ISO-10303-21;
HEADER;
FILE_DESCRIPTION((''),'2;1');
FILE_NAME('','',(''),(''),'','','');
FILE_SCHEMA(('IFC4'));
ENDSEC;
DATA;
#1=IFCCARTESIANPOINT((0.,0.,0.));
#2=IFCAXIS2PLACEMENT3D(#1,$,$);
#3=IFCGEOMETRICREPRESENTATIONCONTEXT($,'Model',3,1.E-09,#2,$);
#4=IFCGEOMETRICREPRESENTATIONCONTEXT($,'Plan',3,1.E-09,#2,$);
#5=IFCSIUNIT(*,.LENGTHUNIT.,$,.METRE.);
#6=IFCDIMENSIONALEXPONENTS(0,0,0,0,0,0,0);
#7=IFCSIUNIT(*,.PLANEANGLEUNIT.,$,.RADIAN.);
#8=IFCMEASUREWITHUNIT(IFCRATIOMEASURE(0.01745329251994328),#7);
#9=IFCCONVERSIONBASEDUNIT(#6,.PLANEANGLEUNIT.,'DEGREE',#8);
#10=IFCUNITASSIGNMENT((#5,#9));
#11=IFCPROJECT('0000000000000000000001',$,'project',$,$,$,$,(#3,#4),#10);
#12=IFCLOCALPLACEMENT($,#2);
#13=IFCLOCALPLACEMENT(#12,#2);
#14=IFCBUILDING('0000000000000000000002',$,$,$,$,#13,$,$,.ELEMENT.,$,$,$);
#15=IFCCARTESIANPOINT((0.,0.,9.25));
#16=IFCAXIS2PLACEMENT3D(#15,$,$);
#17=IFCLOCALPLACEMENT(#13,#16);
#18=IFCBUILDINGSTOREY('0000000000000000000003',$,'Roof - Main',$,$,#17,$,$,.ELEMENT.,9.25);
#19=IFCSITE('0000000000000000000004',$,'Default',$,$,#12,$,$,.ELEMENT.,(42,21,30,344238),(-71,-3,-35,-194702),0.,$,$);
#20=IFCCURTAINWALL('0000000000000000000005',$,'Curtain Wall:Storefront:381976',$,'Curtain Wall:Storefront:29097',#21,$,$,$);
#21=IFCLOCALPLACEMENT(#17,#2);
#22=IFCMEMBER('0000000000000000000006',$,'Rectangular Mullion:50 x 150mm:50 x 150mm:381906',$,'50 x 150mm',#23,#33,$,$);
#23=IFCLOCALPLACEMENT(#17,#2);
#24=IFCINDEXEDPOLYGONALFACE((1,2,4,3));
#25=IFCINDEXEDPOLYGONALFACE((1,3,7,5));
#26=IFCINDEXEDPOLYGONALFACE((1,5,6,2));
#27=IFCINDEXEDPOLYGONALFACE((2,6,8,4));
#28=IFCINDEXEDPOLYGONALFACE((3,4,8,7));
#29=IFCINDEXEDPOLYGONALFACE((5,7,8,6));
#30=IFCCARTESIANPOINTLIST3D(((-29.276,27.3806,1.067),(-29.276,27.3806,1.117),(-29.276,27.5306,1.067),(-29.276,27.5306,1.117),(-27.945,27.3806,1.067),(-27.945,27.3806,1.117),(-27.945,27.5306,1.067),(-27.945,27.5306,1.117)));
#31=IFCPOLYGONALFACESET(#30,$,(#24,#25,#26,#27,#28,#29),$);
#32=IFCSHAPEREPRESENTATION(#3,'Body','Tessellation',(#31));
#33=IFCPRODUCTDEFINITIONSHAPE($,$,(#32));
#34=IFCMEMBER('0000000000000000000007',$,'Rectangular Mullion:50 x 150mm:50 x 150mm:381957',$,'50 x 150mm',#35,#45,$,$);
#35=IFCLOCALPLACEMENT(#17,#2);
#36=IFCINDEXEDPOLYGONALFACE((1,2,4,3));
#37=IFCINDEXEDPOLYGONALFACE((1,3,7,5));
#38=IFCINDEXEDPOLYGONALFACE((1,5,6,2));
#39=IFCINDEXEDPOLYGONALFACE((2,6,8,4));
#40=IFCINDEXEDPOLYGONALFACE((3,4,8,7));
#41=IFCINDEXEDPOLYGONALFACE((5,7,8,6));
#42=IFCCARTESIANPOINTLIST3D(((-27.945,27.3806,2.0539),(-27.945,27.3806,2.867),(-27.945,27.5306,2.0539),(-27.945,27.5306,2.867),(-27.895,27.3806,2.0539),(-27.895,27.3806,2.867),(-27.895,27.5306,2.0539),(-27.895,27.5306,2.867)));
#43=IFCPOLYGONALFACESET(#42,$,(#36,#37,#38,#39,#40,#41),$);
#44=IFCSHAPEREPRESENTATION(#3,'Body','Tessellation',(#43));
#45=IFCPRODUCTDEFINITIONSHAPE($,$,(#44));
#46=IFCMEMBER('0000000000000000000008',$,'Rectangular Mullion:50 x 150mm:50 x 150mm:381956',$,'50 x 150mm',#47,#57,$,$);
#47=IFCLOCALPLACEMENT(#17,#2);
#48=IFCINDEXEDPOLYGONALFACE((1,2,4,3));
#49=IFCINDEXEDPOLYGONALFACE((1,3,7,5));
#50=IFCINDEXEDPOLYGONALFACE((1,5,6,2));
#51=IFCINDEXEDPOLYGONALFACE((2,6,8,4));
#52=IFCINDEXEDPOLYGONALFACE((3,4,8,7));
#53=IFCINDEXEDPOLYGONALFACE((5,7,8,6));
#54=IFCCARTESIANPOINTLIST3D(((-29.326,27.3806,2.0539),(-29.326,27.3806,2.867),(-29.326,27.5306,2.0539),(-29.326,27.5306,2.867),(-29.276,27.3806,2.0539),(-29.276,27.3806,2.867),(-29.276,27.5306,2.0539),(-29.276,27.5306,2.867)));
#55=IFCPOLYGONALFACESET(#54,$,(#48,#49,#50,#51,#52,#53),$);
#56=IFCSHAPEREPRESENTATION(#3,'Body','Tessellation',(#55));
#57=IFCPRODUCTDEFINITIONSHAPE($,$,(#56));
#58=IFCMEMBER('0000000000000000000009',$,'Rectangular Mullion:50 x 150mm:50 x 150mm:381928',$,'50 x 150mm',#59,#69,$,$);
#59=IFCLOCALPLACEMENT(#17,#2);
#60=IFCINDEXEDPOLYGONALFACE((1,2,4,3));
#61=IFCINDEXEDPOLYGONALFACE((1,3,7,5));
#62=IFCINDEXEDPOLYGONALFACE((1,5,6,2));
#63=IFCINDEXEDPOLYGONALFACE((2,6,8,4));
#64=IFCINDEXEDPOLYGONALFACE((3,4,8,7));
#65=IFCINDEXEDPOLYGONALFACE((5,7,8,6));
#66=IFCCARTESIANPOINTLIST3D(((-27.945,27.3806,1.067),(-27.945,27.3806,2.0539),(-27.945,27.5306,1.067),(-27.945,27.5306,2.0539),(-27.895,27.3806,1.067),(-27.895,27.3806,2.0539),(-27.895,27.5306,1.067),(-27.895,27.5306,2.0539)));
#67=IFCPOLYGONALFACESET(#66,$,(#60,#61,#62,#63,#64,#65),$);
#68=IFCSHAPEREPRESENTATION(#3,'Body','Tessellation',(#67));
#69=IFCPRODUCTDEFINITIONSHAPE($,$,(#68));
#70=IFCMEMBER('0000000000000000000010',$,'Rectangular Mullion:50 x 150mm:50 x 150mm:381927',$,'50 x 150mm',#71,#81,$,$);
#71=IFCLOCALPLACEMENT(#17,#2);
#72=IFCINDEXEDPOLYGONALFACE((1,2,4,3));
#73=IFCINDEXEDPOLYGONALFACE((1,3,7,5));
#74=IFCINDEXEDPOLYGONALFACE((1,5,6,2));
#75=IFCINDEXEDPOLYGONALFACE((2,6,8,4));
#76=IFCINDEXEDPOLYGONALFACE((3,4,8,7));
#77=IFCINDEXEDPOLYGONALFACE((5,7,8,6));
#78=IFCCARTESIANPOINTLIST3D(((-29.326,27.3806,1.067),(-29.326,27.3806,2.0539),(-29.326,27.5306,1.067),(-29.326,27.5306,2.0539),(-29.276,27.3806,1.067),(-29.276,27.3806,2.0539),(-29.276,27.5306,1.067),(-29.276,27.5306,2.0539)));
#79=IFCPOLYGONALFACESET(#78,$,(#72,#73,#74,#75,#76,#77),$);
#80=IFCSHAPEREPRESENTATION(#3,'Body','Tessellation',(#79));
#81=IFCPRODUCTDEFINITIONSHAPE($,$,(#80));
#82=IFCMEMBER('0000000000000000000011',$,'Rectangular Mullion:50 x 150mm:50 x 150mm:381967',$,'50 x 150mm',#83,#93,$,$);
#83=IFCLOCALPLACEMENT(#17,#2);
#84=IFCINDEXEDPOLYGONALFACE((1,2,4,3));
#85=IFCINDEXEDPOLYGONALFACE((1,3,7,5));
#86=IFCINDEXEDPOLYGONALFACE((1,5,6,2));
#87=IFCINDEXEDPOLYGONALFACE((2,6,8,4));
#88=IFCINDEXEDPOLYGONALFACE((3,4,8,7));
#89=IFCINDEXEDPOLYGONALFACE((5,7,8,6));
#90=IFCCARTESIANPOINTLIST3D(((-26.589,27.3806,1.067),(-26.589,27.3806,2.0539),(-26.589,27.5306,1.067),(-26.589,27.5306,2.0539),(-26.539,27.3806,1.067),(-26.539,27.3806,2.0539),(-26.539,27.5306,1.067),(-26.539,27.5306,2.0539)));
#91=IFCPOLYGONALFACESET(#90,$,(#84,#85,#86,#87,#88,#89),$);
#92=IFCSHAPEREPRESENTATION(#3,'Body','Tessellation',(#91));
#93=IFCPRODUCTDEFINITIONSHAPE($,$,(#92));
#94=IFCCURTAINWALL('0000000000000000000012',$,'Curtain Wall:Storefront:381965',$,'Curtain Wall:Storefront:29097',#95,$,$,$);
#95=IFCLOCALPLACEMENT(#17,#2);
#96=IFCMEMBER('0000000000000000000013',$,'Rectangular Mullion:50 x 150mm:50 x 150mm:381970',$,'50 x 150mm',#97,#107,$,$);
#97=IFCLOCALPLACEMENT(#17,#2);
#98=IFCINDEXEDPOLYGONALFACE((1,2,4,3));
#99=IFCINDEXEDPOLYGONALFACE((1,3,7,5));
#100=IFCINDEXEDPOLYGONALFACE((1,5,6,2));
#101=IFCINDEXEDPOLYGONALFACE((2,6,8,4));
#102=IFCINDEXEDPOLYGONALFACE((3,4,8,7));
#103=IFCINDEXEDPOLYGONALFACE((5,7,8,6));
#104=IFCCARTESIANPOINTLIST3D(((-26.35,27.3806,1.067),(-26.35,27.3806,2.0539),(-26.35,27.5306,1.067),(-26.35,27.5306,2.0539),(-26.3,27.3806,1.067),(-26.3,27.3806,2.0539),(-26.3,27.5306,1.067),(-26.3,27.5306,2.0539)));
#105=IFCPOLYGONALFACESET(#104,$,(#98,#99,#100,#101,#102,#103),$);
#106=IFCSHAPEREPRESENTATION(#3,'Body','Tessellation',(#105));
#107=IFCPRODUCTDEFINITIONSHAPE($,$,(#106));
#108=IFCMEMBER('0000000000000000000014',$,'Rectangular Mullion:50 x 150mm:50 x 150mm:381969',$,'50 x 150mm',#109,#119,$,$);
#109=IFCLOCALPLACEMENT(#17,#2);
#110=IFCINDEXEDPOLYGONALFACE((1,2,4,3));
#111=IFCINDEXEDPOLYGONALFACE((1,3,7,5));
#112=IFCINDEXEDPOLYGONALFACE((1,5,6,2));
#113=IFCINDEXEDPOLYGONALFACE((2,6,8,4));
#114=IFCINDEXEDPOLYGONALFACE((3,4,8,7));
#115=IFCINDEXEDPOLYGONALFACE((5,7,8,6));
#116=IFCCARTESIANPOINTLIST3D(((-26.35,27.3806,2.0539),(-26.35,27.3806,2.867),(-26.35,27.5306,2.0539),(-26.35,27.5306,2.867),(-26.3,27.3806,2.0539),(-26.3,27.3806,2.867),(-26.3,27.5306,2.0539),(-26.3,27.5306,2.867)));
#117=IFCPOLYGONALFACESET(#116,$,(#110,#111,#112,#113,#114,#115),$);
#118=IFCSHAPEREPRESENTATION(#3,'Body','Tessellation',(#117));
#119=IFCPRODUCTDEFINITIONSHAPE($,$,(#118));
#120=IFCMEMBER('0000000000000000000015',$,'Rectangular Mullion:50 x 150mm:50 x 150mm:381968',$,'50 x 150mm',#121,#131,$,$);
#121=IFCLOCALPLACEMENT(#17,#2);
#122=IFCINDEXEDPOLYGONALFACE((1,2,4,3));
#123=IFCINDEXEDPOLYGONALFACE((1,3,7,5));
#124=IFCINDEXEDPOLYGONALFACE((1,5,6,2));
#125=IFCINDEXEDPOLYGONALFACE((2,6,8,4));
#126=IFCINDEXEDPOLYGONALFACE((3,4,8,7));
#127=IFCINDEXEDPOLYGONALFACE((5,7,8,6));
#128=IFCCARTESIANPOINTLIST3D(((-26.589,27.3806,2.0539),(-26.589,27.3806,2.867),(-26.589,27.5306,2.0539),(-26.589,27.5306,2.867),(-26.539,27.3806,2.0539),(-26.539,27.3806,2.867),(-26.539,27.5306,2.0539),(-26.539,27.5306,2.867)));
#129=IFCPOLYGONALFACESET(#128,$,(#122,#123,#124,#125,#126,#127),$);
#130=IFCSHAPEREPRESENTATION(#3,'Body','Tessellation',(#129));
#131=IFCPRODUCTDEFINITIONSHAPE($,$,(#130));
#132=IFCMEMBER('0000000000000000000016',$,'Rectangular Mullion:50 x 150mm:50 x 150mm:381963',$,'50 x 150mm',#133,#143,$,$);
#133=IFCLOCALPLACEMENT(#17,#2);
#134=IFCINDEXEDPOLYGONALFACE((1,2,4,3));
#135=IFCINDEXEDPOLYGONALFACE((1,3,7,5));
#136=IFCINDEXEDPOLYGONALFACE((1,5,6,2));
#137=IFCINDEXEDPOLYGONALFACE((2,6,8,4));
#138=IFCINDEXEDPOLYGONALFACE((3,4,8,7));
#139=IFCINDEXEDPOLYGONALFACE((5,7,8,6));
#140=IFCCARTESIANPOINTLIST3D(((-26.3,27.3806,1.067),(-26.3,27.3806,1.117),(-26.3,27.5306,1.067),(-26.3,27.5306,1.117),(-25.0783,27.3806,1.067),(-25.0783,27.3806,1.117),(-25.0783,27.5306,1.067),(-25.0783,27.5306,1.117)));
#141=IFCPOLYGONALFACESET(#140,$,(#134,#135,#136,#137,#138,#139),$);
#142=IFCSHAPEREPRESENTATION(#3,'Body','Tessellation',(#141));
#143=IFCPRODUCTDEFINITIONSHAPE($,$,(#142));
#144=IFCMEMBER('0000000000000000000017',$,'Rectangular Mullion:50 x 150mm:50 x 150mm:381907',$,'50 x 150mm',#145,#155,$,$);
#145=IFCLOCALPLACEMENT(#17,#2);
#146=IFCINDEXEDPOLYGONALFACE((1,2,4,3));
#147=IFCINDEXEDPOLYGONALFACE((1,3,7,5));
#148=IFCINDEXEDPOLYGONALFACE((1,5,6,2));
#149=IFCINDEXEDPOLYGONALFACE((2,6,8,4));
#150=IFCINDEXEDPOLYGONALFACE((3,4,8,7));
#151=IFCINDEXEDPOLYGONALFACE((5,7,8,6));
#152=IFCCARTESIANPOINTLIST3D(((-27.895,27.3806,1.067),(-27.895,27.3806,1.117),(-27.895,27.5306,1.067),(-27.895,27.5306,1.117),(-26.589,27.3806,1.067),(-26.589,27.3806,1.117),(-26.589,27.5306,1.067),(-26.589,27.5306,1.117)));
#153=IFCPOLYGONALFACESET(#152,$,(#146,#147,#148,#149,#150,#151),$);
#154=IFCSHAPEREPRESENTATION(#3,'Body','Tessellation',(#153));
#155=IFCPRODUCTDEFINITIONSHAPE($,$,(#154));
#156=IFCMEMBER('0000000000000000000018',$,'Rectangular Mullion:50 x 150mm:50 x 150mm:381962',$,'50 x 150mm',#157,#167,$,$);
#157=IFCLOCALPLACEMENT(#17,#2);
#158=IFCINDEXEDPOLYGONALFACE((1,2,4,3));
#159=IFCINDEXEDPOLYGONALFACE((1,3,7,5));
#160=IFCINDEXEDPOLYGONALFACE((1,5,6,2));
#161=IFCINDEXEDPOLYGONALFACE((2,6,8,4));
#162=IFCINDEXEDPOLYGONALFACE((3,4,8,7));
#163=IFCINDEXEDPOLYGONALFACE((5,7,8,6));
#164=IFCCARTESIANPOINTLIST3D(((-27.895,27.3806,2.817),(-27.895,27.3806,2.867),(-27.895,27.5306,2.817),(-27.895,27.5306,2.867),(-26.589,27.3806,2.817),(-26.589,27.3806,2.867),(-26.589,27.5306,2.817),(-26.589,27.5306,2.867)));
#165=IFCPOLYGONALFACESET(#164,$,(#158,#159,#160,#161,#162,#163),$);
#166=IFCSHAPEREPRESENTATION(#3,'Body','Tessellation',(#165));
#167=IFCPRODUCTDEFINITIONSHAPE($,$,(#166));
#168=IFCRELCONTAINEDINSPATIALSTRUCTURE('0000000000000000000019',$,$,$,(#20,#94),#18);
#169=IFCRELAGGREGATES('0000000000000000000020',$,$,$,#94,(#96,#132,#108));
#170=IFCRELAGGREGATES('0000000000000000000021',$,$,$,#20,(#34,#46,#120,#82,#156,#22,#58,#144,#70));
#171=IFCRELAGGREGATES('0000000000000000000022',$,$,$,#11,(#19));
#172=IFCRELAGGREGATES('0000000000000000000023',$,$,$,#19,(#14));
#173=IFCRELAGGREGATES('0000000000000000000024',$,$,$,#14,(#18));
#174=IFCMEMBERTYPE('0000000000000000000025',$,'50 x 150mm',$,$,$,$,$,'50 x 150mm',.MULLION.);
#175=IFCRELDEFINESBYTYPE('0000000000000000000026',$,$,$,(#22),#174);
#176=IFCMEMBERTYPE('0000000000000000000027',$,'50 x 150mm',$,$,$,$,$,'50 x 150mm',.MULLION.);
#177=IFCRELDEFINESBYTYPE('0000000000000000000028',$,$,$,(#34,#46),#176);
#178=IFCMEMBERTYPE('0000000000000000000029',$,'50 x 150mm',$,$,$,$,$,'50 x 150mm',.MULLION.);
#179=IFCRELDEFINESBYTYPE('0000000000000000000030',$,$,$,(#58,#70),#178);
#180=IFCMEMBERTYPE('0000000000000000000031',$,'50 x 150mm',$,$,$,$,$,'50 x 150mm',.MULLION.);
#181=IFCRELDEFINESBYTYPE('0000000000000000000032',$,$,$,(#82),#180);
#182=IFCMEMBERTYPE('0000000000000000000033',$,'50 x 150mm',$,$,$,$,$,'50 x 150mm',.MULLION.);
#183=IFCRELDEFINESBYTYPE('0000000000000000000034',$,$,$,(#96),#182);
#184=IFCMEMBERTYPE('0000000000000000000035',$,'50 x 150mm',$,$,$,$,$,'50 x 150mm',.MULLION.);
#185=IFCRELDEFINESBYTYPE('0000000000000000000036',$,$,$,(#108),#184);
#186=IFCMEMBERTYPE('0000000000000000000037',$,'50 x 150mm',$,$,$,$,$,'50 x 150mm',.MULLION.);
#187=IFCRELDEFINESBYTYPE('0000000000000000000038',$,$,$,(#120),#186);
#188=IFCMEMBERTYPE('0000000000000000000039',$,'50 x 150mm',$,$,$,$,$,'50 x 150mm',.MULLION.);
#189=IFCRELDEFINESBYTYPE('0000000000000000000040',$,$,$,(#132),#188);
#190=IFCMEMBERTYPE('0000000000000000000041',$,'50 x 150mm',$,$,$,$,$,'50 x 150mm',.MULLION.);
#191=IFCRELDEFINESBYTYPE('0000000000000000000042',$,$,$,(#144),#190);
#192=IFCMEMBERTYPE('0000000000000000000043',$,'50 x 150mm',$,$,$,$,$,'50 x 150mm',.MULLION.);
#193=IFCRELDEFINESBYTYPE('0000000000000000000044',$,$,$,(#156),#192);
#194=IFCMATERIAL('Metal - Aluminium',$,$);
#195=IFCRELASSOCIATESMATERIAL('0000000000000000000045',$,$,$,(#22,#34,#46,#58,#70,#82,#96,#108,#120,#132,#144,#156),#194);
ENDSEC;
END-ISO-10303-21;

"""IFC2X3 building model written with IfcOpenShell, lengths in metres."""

from ifc_helpers import new_model, entity, si_unit, converted_unit, frame, origin, origin_2d_with_axis, place, context, project, spatial, rectangle, extrude, source, transform, mapped, material, type_object, type_shapes, element, aggregate, save


model = new_model("IFC2X3")

# Units and contexts
model_context = context("Model", 3, precision=1e-09, world=origin())
plan_context = context("Plan", 3, precision=1e-09, world=origin())
ifc_project = project(units=[si_unit("LENGTHUNIT", "METRE"), converted_unit("PLANEANGLEUNIT", "DEGREE", entity("IfcRatioMeasure", 0.01745329251994328), si_unit("PLANEANGLEUNIT", "RADIAN"), dimensions=[0, 0, 0, 0, 0, 0, 0])], contexts=[model_context, plan_context])

# Site, building, storey
site_placement = place(None, origin())
site = spatial("IfcSite", under=ifc_project, at=site_placement, Name="Default", CompositionType="ELEMENT", RefLatitude=(42, 21, 30, 344238), RefLongitude=(-71, -3, -35, -194702), RefElevation=0.0)
building_placement = place(site_placement, origin())
building = spatial("IfcBuilding", under=site, at=building_placement, CompositionType="ELEMENT")
storey_placement = place(building_placement, frame((0.0, 0.0, 9.25)))
storey = spatial("IfcBuildingStorey", under=building, at=storey_placement, Name="Roof - Main", CompositionType="ELEMENT", Elevation=9.25)

# Curtain walls, members
curtain_wall_1_placement = place(storey_placement, origin())
curtain_wall_1 = element("IfcCurtainWall", 1, at=curtain_wall_1_placement, inside=storey, Name="Curtain Wall:Storefront:381976", ObjectType="Curtain Wall:Storefront:29097")
ifc_material_1 = material(Name="Metal - Aluminium")
member_type_1 = type_object("IfcMemberType", Name="50 x 150mm", ElementType="50 x 150mm", PredefinedType="MULLION")
shared_shape_1 = source(origin(), model_context, "Body", "SweptSolid", [
    extrude(rectangle(XDim=0.05, YDim=0.15, at=origin_2d_with_axis()), frame((-0.025, 0.0, -1.331), z_axis=(0.0, 0.0, 1.0), x_axis=(-1.0, 0.0, 0.0)), (0.0, 0.0, 1.0), 1.331),
])
type_shapes(member_type_1, [shared_shape_1])
member_1_placement = place(storey_placement, frame((-29.276, 27.4556, 1.067), z_axis=(-1.0, 0.0, 0.0), x_axis=(0.0, 0.0, -1.0)))
member_1 = element("IfcMember", 2, at=member_1_placement, type_object=member_type_1, material=ifc_material_1, Name="Rectangular Mullion:50 x 150mm:50 x 150mm:381906", ObjectType="50 x 150mm", context=model_context, shape_type="MappedRepresentation", body=[
    mapped(shared_shape_1, transform((0.0, 0.0, 0.0), scale=1.0)),
])
member_type_2 = type_object("IfcMemberType", Name="50 x 150mm", ElementType="50 x 150mm", PredefinedType="MULLION")
shared_shape_2 = source(origin(), model_context, "Body", "SweptSolid", [
    extrude(rectangle(XDim=0.05, YDim=0.15, at=origin_2d_with_axis()), frame((0.0, 0.0, -0.8131), z_axis=(0.0, 0.0, 1.0), x_axis=(-1.0, 0.0, 0.0)), (0.0, 0.0, 1.0), 0.8131),
])
type_shapes(member_type_2, [shared_shape_2])
member_2_placement = place(storey_placement, frame((-27.92, 27.4556, 2.0539), z_axis=(0.0, 0.0, -1.0), x_axis=(1.0, 0.0, 0.0)))
member_2 = element("IfcMember", 3, at=member_2_placement, type_object=member_type_2, material=ifc_material_1, Name="Rectangular Mullion:50 x 150mm:50 x 150mm:381957", ObjectType="50 x 150mm", context=model_context, shape_type="MappedRepresentation", body=[
    mapped(shared_shape_2, transform((0.0, 0.0, 0.0), scale=1.0)),
])
member_3_placement = place(storey_placement, frame((-29.301, 27.4556, 2.0539), z_axis=(0.0, 0.0, -1.0), x_axis=(1.0, 0.0, 0.0)))
member_3 = element("IfcMember", 4, at=member_3_placement, type_object=member_type_2, material=ifc_material_1, Name="Rectangular Mullion:50 x 150mm:50 x 150mm:381956", ObjectType="50 x 150mm", context=model_context, shape_type="MappedRepresentation", body=[
    mapped(shared_shape_2, transform((0.0, 0.0, 0.0), scale=1.0)),
])
member_type_3 = type_object("IfcMemberType", Name="50 x 150mm", ElementType="50 x 150mm", PredefinedType="MULLION")
shared_shape_3 = source(origin(), model_context, "Body", "SweptSolid", [
    extrude(rectangle(XDim=0.05, YDim=0.15, at=origin_2d_with_axis()), frame((0.0, 0.0, -0.9869), z_axis=(0.0, 0.0, 1.0), x_axis=(-1.0, 0.0, 0.0)), (0.0, 0.0, 1.0), 0.9869),
])
type_shapes(member_type_3, [shared_shape_3])
member_4_placement = place(storey_placement, frame((-27.92, 27.4556, 1.067), z_axis=(0.0, 0.0, -1.0), x_axis=(1.0, 0.0, 0.0)))
member_4 = element("IfcMember", 5, at=member_4_placement, type_object=member_type_3, material=ifc_material_1, Name="Rectangular Mullion:50 x 150mm:50 x 150mm:381928", ObjectType="50 x 150mm", context=model_context, shape_type="MappedRepresentation", body=[
    mapped(shared_shape_3, transform((0.0, 0.0, 0.0), scale=1.0)),
])
member_5_placement = place(storey_placement, frame((-29.301, 27.4556, 1.067), z_axis=(0.0, 0.0, -1.0), x_axis=(1.0, 0.0, 0.0)))
member_5 = element("IfcMember", 6, at=member_5_placement, type_object=member_type_3, material=ifc_material_1, Name="Rectangular Mullion:50 x 150mm:50 x 150mm:381927", ObjectType="50 x 150mm", context=model_context, shape_type="MappedRepresentation", body=[
    mapped(shared_shape_3, transform((0.0, 0.0, 0.0), scale=1.0)),
])
member_type_4 = type_object("IfcMemberType", Name="50 x 150mm", ElementType="50 x 150mm", PredefinedType="MULLION")
shared_shape_4 = source(origin(), model_context, "Body", "SweptSolid", [
    extrude(rectangle(XDim=0.05, YDim=0.15, at=origin_2d_with_axis()), frame((-0.025, 0.0, -0.9869), z_axis=(0.0, 0.0, 1.0), x_axis=(-1.0, 0.0, 0.0)), (0.0, 0.0, 1.0), 0.9869),
])
type_shapes(member_type_4, [shared_shape_4])
member_6_placement = place(storey_placement, frame((-26.539, 27.4556, 1.067), z_axis=(0.0, 0.0, -1.0), x_axis=(1.0, 0.0, 0.0)))
member_6 = element("IfcMember", 7, at=member_6_placement, type_object=member_type_4, material=ifc_material_1, Name="Rectangular Mullion:50 x 150mm:50 x 150mm:381967", ObjectType="50 x 150mm", context=model_context, shape_type="MappedRepresentation", body=[
    mapped(shared_shape_4, transform((0.0, 0.0, 0.0), scale=1.0)),
])
curtain_wall_2_placement = place(storey_placement, origin())
curtain_wall_2 = element("IfcCurtainWall", 8, at=curtain_wall_2_placement, inside=storey, Name="Curtain Wall:Storefront:381965", ObjectType="Curtain Wall:Storefront:29097")
member_type_5 = type_object("IfcMemberType", Name="50 x 150mm", ElementType="50 x 150mm", PredefinedType="MULLION")
shared_shape_5 = source(origin(), model_context, "Body", "SweptSolid", [
    extrude(rectangle(XDim=0.05, YDim=0.15, at=origin_2d_with_axis()), frame((-0.025, 0.0, -0.9869), z_axis=(0.0, 0.0, 1.0), x_axis=(-1.0, 0.0, 0.0)), (0.0, 0.0, 1.0), 0.9869),
])
type_shapes(member_type_5, [shared_shape_5])
member_7_placement = place(storey_placement, frame((-26.35, 27.4556, 2.0539), z_axis=(0.0, 0.0, 1.0), x_axis=(-1.0, 0.0, 0.0)))
member_7 = element("IfcMember", 9, at=member_7_placement, type_object=member_type_5, material=ifc_material_1, Name="Rectangular Mullion:50 x 150mm:50 x 150mm:381970", ObjectType="50 x 150mm", context=model_context, shape_type="MappedRepresentation", body=[
    mapped(shared_shape_5, transform((0.0, 0.0, 0.0), scale=1.0)),
])
member_type_6 = type_object("IfcMemberType", Name="50 x 150mm", ElementType="50 x 150mm", PredefinedType="MULLION")
shared_shape_6 = source(origin(), model_context, "Body", "SweptSolid", [
    extrude(rectangle(XDim=0.05, YDim=0.15, at=origin_2d_with_axis()), frame((-0.025, 0.0, -0.8131), z_axis=(0.0, 0.0, 1.0), x_axis=(-1.0, 0.0, 0.0)), (0.0, 0.0, 1.0), 0.8131),
])
type_shapes(member_type_6, [shared_shape_6])
member_8_placement = place(storey_placement, frame((-26.35, 27.4556, 2.867), z_axis=(0.0, 0.0, 1.0), x_axis=(-1.0, 0.0, 0.0)))
member_8 = element("IfcMember", 10, at=member_8_placement, type_object=member_type_6, material=ifc_material_1, Name="Rectangular Mullion:50 x 150mm:50 x 150mm:381969", ObjectType="50 x 150mm", context=model_context, shape_type="MappedRepresentation", body=[
    mapped(shared_shape_6, transform((0.0, 0.0, 0.0), scale=1.0)),
])

# Members
member_type_7 = type_object("IfcMemberType", Name="50 x 150mm", ElementType="50 x 150mm", PredefinedType="MULLION")
shared_shape_7 = source(origin(), model_context, "Body", "SweptSolid", [
    extrude(rectangle(XDim=0.05, YDim=0.15, at=origin_2d_with_axis()), frame((-0.025, 0.0, -0.8131), z_axis=(0.0, 0.0, 1.0), x_axis=(-1.0, 0.0, 0.0)), (0.0, 0.0, 1.0), 0.8131),
])
type_shapes(member_type_7, [shared_shape_7])
member_9_placement = place(storey_placement, frame((-26.539, 27.4556, 2.0539), z_axis=(0.0, 0.0, -1.0), x_axis=(1.0, 0.0, 0.0)))
member_9 = element("IfcMember", 11, at=member_9_placement, type_object=member_type_7, material=ifc_material_1, Name="Rectangular Mullion:50 x 150mm:50 x 150mm:381968", ObjectType="50 x 150mm", context=model_context, shape_type="MappedRepresentation", body=[
    mapped(shared_shape_7, transform((0.0, 0.0, 0.0), scale=1.0)),
])
member_type_8 = type_object("IfcMemberType", Name="50 x 150mm", ElementType="50 x 150mm", PredefinedType="MULLION")
shared_shape_8 = source(origin(), model_context, "Body", "SweptSolid", [
    extrude(rectangle(XDim=0.05, YDim=0.15, at=origin_2d_with_axis()), frame((-0.025, 0.0, -1.2217), z_axis=(0.0, 0.0, 1.0), x_axis=(-1.0, 0.0, 0.0)), (0.0, 0.0, 1.0), 1.2217),
])
type_shapes(member_type_8, [shared_shape_8])
member_10_placement = place(storey_placement, frame((-26.3, 27.4556, 1.067), z_axis=(-1.0, 0.0, 0.0), x_axis=(0.0, 0.0, -1.0)))
member_10 = element("IfcMember", 12, at=member_10_placement, type_object=member_type_8, material=ifc_material_1, Name="Rectangular Mullion:50 x 150mm:50 x 150mm:381963", ObjectType="50 x 150mm", context=model_context, shape_type="MappedRepresentation", body=[
    mapped(shared_shape_8, transform((0.0, 0.0, 0.0), scale=1.0)),
])
member_type_9 = type_object("IfcMemberType", Name="50 x 150mm", ElementType="50 x 150mm", PredefinedType="MULLION")
shared_shape_9 = source(origin(), model_context, "Body", "SweptSolid", [
    extrude(rectangle(XDim=0.05, YDim=0.15, at=origin_2d_with_axis()), frame((-0.025, 0.0, -1.306), z_axis=(0.0, 0.0, 1.0), x_axis=(-1.0, 0.0, 0.0)), (0.0, 0.0, 1.0), 1.306),
])
type_shapes(member_type_9, [shared_shape_9])
member_11_placement = place(storey_placement, frame((-27.895, 27.4556, 1.067), z_axis=(-1.0, 0.0, 0.0), x_axis=(0.0, 0.0, -1.0)))
member_11 = element("IfcMember", 13, at=member_11_placement, type_object=member_type_9, material=ifc_material_1, Name="Rectangular Mullion:50 x 150mm:50 x 150mm:381907", ObjectType="50 x 150mm", context=model_context, shape_type="MappedRepresentation", body=[
    mapped(shared_shape_9, transform((0.0, 0.0, 0.0), scale=1.0)),
])
member_type_10 = type_object("IfcMemberType", Name="50 x 150mm", ElementType="50 x 150mm", PredefinedType="MULLION")
shared_shape_10 = source(origin(), model_context, "Body", "SweptSolid", [
    extrude(rectangle(XDim=0.05, YDim=0.15, at=origin_2d_with_axis()), frame((-0.025, 0.0, -1.306), z_axis=(0.0, 0.0, 1.0), x_axis=(-1.0, 0.0, 0.0)), (0.0, 0.0, 1.0), 1.306),
])
type_shapes(member_type_10, [shared_shape_10])
member_12_placement = place(storey_placement, frame((-26.589, 27.4556, 2.867), z_axis=(1.0, 0.0, 0.0), x_axis=(0.0, 0.0, 1.0)))
member_12 = element("IfcMember", 14, at=member_12_placement, type_object=member_type_10, material=ifc_material_1, Name="Rectangular Mullion:50 x 150mm:50 x 150mm:381962", ObjectType="50 x 150mm", context=model_context, shape_type="MappedRepresentation", body=[
    mapped(shared_shape_10, transform((0.0, 0.0, 0.0), scale=1.0)),
])

aggregate(curtain_wall_2, [member_7, member_10, member_8])
aggregate(curtain_wall_1, [member_2, member_3, member_9, member_6, member_12, member_1, member_4, member_11, member_5])

save(model, "model.ifc")
